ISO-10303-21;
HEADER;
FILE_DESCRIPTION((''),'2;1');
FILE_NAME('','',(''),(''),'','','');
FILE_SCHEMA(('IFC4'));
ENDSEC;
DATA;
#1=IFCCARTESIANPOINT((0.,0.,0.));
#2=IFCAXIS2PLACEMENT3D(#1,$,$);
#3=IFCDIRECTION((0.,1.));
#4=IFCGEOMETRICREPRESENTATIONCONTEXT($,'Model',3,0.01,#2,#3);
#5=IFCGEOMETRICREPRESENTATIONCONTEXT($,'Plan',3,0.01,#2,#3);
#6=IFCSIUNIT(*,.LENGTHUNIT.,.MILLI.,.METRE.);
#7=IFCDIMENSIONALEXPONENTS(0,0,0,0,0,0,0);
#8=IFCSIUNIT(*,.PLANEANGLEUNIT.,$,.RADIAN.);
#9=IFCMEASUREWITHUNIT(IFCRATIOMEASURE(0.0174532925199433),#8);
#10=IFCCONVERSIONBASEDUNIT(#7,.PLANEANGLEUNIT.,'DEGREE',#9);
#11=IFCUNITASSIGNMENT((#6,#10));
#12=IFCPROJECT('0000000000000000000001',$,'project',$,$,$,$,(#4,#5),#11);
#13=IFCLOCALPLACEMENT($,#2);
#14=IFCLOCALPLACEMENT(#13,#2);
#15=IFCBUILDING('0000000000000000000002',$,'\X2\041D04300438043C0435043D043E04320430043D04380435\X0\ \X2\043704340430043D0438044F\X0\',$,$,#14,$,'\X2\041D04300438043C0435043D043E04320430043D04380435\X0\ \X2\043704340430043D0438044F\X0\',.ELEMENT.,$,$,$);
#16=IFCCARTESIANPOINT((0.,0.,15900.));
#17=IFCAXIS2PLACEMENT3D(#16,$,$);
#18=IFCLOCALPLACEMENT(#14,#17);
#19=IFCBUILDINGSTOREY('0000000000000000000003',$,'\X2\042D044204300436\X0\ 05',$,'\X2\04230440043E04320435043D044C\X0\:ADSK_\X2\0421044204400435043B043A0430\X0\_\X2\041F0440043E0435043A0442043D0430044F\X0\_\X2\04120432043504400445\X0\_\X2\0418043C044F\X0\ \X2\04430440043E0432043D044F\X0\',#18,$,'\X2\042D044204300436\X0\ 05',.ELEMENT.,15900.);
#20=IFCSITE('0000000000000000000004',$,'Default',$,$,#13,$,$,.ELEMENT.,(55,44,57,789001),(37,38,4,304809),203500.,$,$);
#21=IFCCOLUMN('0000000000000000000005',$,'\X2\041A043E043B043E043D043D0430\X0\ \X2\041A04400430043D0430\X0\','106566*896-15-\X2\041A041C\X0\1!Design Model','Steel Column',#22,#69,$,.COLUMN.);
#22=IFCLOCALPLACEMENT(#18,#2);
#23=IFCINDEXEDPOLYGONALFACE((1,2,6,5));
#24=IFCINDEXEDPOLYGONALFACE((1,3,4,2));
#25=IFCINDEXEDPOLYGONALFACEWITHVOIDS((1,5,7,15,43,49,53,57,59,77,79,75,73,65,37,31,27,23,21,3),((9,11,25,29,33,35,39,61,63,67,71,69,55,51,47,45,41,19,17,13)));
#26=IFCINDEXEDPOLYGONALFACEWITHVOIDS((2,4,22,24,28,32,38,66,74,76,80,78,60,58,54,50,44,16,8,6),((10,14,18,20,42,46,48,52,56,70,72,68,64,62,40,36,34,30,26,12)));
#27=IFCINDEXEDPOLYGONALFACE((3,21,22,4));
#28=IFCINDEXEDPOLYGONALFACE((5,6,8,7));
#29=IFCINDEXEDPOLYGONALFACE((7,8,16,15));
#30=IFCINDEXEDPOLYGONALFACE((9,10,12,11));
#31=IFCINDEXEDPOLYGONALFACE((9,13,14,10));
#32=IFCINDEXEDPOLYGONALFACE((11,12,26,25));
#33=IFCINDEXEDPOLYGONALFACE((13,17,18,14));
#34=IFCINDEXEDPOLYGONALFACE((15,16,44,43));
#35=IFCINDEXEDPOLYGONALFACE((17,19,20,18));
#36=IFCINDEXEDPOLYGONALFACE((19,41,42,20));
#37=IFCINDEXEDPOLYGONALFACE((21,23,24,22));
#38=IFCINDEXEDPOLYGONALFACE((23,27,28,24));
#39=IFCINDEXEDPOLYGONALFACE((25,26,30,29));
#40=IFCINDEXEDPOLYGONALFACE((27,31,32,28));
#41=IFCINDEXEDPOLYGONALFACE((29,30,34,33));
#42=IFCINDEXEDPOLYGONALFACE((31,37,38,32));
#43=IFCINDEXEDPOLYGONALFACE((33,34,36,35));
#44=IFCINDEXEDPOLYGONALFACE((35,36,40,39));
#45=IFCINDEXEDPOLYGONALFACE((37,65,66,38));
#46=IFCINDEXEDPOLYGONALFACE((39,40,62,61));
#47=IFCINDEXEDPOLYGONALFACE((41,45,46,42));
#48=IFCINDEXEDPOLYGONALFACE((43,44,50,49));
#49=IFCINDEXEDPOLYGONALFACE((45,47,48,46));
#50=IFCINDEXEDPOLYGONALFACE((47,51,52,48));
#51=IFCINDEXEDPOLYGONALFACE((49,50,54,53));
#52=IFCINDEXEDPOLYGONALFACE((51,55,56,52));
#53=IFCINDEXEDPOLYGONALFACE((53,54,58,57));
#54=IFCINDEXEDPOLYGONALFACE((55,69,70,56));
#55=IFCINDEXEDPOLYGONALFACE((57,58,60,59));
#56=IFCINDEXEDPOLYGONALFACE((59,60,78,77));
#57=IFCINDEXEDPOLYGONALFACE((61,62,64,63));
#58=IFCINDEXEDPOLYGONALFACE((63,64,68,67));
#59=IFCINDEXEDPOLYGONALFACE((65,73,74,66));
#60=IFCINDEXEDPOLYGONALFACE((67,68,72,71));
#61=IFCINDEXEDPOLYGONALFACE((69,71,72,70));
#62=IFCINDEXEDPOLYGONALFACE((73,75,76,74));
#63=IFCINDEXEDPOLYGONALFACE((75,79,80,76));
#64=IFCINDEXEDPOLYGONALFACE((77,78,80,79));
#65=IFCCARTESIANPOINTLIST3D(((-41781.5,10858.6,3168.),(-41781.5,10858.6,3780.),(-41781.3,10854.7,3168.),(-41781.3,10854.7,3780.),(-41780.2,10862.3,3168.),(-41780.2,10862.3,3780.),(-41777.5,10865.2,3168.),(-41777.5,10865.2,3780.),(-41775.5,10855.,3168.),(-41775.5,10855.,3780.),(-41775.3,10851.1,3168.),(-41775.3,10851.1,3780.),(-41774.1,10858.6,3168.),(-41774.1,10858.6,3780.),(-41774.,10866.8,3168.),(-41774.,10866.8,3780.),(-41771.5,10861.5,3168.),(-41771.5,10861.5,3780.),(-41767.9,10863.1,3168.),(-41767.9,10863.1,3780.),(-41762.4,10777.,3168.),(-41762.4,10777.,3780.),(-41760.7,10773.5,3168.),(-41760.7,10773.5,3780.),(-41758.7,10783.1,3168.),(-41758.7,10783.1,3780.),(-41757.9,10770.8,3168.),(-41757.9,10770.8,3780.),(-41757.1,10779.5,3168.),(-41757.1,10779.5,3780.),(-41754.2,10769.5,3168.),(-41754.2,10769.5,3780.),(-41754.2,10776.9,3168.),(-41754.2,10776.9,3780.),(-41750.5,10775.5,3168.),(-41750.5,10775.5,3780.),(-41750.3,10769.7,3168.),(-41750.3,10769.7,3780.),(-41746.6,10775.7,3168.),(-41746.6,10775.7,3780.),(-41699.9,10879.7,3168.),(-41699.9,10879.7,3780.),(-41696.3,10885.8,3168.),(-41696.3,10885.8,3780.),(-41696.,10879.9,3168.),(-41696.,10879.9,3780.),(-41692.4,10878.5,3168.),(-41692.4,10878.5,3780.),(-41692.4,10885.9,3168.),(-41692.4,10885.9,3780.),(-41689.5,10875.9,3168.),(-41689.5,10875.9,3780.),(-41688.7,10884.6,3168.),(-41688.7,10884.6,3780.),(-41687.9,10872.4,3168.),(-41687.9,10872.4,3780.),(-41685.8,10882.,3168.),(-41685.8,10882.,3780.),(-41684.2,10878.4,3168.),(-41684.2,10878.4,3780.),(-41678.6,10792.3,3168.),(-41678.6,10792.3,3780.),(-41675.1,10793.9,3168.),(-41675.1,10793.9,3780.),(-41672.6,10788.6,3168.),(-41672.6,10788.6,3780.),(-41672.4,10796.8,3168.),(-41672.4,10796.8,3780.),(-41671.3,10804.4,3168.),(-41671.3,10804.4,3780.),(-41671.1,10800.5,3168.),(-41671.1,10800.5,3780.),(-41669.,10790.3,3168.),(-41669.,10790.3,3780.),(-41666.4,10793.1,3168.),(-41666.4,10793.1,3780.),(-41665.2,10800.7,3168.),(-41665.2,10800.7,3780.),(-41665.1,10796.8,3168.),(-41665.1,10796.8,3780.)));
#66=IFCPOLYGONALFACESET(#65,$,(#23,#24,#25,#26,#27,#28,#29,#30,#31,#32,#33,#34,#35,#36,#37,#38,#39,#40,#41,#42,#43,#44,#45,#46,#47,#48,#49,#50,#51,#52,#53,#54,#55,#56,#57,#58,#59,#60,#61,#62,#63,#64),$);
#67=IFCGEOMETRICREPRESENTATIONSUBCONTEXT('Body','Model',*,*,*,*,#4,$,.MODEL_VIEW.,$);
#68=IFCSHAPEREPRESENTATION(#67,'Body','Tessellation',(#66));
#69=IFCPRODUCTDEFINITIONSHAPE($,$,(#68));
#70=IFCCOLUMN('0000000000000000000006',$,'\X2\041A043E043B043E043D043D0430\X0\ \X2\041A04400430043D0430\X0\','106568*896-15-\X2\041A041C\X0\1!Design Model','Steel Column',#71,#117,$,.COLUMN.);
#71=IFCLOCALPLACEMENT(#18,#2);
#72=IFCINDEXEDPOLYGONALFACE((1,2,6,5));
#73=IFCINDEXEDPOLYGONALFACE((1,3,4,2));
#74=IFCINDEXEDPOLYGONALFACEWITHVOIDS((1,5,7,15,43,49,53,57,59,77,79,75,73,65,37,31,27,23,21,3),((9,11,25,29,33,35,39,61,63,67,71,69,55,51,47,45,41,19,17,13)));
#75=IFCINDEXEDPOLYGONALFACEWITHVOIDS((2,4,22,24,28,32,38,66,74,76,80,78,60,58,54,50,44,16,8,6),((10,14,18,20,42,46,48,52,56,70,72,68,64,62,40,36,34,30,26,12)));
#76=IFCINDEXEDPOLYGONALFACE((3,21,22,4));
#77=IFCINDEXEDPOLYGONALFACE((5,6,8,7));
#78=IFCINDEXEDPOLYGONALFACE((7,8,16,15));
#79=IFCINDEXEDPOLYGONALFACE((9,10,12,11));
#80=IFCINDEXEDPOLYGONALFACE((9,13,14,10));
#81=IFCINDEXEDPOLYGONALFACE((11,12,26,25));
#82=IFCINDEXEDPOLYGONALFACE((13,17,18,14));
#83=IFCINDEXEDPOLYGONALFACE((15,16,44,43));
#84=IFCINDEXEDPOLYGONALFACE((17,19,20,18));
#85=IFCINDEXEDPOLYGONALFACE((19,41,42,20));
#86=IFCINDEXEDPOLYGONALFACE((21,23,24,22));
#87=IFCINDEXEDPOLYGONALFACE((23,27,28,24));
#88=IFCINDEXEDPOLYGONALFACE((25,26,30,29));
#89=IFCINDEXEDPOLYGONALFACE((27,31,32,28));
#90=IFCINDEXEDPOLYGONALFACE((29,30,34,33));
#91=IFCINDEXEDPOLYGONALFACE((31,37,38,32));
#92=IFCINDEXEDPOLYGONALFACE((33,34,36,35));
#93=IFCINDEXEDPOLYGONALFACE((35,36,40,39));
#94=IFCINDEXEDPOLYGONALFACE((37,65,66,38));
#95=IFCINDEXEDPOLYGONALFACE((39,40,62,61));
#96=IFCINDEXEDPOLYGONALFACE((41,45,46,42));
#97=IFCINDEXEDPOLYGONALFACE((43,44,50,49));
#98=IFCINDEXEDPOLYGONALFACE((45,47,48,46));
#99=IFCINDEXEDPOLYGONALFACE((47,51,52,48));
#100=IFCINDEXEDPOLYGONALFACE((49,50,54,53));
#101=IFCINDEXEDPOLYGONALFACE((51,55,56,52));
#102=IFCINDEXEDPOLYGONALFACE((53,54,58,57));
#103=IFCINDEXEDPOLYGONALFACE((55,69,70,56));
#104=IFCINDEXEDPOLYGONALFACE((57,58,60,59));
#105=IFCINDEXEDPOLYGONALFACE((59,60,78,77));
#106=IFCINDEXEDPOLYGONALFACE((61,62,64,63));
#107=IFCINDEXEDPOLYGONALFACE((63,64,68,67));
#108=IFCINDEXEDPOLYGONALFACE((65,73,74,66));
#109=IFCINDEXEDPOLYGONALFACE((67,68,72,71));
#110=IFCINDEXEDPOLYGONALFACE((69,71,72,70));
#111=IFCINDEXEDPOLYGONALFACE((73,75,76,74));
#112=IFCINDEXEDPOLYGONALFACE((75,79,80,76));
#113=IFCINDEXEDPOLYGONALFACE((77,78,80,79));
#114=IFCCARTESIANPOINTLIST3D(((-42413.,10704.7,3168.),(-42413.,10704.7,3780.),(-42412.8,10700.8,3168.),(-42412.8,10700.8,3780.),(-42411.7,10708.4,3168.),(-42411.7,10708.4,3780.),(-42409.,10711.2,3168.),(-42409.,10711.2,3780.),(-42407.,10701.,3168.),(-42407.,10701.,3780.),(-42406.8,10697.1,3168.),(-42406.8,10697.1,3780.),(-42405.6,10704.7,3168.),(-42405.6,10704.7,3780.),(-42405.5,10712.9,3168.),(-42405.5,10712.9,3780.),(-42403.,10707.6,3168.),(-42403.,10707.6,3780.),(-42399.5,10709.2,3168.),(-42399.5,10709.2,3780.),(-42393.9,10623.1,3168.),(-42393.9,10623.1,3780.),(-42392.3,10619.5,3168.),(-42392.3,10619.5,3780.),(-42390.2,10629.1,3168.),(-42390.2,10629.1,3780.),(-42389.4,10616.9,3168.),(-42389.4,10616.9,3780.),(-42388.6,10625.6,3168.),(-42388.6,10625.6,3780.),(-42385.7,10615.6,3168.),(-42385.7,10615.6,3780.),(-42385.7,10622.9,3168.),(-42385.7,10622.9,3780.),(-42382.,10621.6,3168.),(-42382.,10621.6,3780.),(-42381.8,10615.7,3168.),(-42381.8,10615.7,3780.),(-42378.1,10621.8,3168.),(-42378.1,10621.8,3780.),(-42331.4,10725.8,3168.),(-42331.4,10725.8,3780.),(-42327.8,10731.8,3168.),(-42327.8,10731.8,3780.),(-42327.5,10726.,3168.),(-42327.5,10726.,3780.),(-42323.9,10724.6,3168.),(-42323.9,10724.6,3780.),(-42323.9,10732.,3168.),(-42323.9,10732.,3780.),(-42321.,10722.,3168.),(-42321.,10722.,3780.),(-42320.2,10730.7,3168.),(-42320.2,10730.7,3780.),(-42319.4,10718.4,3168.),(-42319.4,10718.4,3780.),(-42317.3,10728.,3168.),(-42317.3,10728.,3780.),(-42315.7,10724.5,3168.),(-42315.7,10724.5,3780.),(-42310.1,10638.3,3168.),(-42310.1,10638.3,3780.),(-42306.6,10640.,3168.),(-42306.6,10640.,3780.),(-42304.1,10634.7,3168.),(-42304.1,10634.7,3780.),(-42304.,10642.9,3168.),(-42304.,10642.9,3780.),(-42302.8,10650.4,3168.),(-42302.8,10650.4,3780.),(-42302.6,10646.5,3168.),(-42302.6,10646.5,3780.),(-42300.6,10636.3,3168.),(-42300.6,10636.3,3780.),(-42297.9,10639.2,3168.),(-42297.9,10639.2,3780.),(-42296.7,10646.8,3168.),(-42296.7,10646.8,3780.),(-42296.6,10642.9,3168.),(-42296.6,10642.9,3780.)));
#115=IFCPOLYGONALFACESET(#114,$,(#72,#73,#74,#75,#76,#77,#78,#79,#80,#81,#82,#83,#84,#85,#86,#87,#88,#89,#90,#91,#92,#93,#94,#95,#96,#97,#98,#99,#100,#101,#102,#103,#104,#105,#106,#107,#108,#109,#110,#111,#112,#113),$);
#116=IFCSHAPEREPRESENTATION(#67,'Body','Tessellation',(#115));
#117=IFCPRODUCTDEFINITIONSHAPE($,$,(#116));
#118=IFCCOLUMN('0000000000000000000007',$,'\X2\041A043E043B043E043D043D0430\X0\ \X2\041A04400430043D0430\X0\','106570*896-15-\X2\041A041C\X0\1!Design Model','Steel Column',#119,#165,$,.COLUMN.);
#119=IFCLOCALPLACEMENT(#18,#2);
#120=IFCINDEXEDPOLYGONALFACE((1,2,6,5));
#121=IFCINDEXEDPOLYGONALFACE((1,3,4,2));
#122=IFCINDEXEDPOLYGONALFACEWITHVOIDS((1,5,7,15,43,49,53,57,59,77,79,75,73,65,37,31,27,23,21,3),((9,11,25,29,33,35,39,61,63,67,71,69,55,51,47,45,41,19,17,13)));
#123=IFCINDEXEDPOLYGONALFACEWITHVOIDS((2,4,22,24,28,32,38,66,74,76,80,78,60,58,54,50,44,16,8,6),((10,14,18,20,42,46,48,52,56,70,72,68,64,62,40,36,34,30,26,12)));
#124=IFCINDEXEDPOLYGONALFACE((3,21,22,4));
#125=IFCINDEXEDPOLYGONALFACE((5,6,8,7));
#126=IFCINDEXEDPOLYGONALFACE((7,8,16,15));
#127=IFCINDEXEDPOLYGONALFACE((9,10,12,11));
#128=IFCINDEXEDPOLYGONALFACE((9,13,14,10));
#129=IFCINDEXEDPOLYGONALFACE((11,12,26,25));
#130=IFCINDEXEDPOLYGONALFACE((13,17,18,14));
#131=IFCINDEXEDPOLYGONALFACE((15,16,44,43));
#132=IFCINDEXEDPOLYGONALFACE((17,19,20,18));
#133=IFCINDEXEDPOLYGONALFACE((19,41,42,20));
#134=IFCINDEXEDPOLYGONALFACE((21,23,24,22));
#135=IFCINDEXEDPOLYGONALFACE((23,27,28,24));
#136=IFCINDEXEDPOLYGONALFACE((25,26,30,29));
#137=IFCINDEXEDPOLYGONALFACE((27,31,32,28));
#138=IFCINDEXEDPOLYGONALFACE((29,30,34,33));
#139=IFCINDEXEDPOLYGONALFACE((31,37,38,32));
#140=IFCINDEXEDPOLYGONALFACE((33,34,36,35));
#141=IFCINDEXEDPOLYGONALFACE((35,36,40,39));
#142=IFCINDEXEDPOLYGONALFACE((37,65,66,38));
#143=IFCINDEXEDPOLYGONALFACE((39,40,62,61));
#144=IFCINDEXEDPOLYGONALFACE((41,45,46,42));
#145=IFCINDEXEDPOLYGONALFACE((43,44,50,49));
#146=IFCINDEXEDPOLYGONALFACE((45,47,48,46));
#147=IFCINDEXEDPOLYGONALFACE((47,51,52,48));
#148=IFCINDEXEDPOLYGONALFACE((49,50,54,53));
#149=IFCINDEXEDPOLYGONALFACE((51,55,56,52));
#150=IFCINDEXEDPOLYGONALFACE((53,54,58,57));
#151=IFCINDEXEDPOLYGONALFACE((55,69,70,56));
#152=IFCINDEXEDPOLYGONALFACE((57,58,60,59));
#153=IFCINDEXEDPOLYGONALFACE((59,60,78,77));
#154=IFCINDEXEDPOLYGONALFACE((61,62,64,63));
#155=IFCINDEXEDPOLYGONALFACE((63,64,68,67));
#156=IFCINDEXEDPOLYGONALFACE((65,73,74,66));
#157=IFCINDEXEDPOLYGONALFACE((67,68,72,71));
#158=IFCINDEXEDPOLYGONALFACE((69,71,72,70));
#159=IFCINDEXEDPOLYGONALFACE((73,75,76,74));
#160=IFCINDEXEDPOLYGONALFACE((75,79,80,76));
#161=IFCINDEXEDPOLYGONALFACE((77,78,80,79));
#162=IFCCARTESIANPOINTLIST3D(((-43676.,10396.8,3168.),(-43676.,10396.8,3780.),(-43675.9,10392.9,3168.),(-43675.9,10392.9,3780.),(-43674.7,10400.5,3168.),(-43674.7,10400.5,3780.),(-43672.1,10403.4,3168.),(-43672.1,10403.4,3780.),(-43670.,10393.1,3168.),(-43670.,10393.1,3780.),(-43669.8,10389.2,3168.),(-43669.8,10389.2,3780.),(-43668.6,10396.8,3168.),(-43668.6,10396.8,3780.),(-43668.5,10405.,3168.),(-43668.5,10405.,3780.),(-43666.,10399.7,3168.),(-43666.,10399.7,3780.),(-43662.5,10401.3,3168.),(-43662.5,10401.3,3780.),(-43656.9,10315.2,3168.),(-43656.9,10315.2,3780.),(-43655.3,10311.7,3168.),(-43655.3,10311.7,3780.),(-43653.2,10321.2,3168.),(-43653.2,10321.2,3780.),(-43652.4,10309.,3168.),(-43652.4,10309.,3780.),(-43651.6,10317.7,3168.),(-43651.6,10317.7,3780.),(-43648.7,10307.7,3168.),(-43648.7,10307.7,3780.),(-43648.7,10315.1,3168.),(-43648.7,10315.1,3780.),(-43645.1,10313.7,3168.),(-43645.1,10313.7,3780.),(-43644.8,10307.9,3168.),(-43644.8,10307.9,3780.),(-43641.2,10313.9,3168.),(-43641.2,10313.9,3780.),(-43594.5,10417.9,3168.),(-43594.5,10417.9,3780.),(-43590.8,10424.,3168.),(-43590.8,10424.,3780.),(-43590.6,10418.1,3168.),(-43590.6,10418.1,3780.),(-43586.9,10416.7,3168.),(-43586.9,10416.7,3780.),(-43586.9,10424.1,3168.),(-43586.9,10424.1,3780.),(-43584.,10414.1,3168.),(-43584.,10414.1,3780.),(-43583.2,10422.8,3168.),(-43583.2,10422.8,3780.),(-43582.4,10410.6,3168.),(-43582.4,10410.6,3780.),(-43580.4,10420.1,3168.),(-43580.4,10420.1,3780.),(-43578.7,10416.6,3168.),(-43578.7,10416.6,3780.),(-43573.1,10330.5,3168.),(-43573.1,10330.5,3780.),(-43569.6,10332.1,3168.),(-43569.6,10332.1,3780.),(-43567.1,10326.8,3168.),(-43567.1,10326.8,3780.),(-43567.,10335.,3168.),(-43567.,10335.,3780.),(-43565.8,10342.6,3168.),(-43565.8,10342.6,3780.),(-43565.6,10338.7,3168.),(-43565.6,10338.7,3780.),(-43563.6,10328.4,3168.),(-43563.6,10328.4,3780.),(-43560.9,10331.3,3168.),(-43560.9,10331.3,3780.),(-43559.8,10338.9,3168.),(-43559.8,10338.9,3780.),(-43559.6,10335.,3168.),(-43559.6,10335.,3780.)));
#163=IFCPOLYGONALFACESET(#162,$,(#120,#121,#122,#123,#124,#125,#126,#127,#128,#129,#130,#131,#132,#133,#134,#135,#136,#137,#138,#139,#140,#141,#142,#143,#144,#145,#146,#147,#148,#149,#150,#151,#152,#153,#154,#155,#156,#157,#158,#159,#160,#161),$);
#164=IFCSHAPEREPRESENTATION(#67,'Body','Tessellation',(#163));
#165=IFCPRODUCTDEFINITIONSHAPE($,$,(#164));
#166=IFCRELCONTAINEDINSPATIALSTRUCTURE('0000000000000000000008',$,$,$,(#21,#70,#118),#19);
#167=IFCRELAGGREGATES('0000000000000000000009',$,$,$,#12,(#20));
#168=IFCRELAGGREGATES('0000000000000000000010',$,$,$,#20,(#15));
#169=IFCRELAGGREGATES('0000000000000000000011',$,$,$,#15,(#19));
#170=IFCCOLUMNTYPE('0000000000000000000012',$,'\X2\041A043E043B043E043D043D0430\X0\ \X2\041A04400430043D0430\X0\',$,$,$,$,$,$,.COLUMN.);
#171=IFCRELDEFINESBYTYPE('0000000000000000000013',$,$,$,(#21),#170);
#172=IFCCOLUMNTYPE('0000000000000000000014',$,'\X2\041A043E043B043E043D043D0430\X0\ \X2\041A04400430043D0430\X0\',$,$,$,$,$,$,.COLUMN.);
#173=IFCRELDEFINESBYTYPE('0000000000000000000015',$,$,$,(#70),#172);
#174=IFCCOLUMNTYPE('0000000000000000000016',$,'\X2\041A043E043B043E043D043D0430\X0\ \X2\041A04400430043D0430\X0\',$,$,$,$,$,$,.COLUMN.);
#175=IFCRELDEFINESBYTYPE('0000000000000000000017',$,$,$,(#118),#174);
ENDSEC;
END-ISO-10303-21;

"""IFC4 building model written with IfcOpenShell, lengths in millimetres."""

from ifc_helpers import new_model, entity, si_unit, converted_unit, direction, frame, origin, place, context, subcontext, project, spatial, indexed_curve, outline, extrude, type_object, element, save


model = new_model("IFC4")

# Units and contexts
model_context = context("Model", 3, precision=0.01, world=origin(), true_north=direction((0.0, 1.0)))
plan_context = context("Plan", 3, precision=0.01, world=origin(), true_north=direction((0.0, 1.0)))
body_context = subcontext(model_context, "Body", "Model", "MODEL_VIEW")
ifc_project = project(units=[si_unit("LENGTHUNIT", "METRE", prefix="MILLI"), converted_unit("PLANEANGLEUNIT", "DEGREE", entity("IfcRatioMeasure", 0.0174532925199433), si_unit("PLANEANGLEUNIT", "RADIAN"), dimensions=[0, 0, 0, 0, 0, 0, 0])], contexts=[model_context, plan_context])

# Site, building, storey
site_placement = place(None, origin())
site = spatial("IfcSite", under=ifc_project, at=site_placement, Name="Default", CompositionType="ELEMENT", RefLatitude=(55, 44, 57, 789001), RefLongitude=(37, 38, 4, 304809), RefElevation=203500.0)
building_placement = place(site_placement, origin())
building = spatial("IfcBuilding", under=site, at=building_placement, Name="Наименование здания", LongName="Наименование здания", CompositionType="ELEMENT")
storey_placement = place(building_placement, frame((0.0, 0.0, 15900.0)))
storey = spatial("IfcBuildingStorey", under=building, at=storey_placement, Name="Этаж 05", ObjectType="Уровень:ADSK_Стрелка_Проектная_Вверх_Имя уровня", LongName="Этаж 05", CompositionType="ELEMENT", Elevation=15900.0)

# Columns
column_type_1 = type_object("IfcColumnType", Name="Колонна Крана", PredefinedType="COLUMN")
column_1_placement = place(storey_placement, origin())
element("IfcColumn", 1, at=column_1_placement, inside=storey, type_object=column_type_1, Name="Колонна Крана", Description="106566*896-15-КМ1!Design Model", ObjectType="Steel Column", PredefinedType="COLUMN", context=body_context, shape_type="SweptSolid", body=[
    extrude(outline(indexed_curve([(29.5, -56.8), (33.4, -56.8), (37.0, -55.3), (39.7, -52.6), (41.2, -49.0), (56.8, 29.5), (56.8, 33.4), (55.3, 37.0), (52.6, 39.7), (49.0, 41.2), (-29.5, 56.8), (-33.4, 56.8), (-37.0, 55.3), (-39.7, 52.6), (-41.2, 49.0), (-56.8, -29.5), (-56.8, -33.4), (-55.3, -37.0), (-52.6, -39.7), (-49.0, -41.2), (29.5, -56.8)], self_intersect=False), holes=[indexed_curve([(-43.1, -37.3), (-46.7, -35.8), (-49.5, -33.1), (-51.0, -29.5), (-51.0, -25.5), (-37.3, 43.1), (-35.8, 46.7), (-33.1, 49.5), (-29.5, 51.0), (-25.5, 51.0), (43.1, 37.3), (46.7, 35.8), (49.5, 33.1), (51.0, 29.5), (51.0, 25.5), (37.3, -43.1), (35.8, -46.7), (33.1, -49.5), (29.5, -51.0), (25.5, -51.0), (-43.1, -37.3)], self_intersect=False)]), frame((-41723.3, 10827.7, 3168.0), z_axis=(0.0, 0.0, 1.0), x_axis=(0.906681, 0.421816, 0.0)), (0.0, 0.0, 1.0), 612.0),
])
column_type_2 = type_object("IfcColumnType", Name="Колонна Крана", PredefinedType="COLUMN")
column_2_placement = place(storey_placement, origin())
element("IfcColumn", 2, at=column_2_placement, inside=storey, type_object=column_type_2, Name="Колонна Крана", Description="106568*896-15-КМ1!Design Model", ObjectType="Steel Column", PredefinedType="COLUMN", context=body_context, shape_type="SweptSolid", body=[
    extrude(outline(indexed_curve([(29.5, -56.8), (33.4, -56.8), (37.0, -55.3), (39.7, -52.6), (41.2, -49.0), (56.8, 29.5), (56.8, 33.4), (55.3, 37.0), (52.6, 39.7), (49.0, 41.2), (-29.5, 56.8), (-33.4, 56.8), (-37.0, 55.3), (-39.7, 52.6), (-41.2, 49.0), (-56.8, -29.5), (-56.8, -33.4), (-55.3, -37.0), (-52.6, -39.7), (-49.0, -41.2), (29.5, -56.8)], self_intersect=False), holes=[indexed_curve([(-43.1, -37.3), (-46.7, -35.8), (-49.5, -33.1), (-51.0, -29.5), (-51.0, -25.5), (-37.3, 43.1), (-35.8, 46.7), (-33.1, 49.5), (-29.5, 51.0), (-25.5, 51.0), (43.1, 37.3), (46.7, 35.8), (49.5, 33.1), (51.0, 29.5), (51.0, 25.5), (37.3, -43.1), (35.8, -46.7), (33.1, -49.5), (29.5, -51.0), (25.5, -51.0), (-43.1, -37.3)], self_intersect=False)]), frame((-42354.8, 10673.8, 3168.0), z_axis=(0.0, 0.0, 1.0), x_axis=(0.906681, 0.421816, 0.0)), (0.0, 0.0, 1.0), 612.0),
])
column_type_3 = type_object("IfcColumnType", Name="Колонна Крана", PredefinedType="COLUMN")
column_3_placement = place(storey_placement, origin())
element("IfcColumn", 3, at=column_3_placement, inside=storey, type_object=column_type_3, Name="Колонна Крана", Description="106570*896-15-КМ1!Design Model", ObjectType="Steel Column", PredefinedType="COLUMN", context=body_context, shape_type="SweptSolid", body=[
    extrude(outline(indexed_curve([(29.5, -56.8), (33.4, -56.8), (37.0, -55.3), (39.7, -52.6), (41.2, -49.0), (56.8, 29.5), (56.8, 33.4), (55.3, 37.0), (52.6, 39.7), (49.0, 41.2), (-29.5, 56.8), (-33.4, 56.8), (-37.0, 55.3), (-39.7, 52.6), (-41.2, 49.0), (-56.8, -29.5), (-56.8, -33.4), (-55.3, -37.0), (-52.6, -39.7), (-49.0, -41.2), (29.5, -56.8)], self_intersect=False), holes=[indexed_curve([(-43.1, -37.3), (-46.7, -35.8), (-49.5, -33.1), (-51.0, -29.5), (-51.0, -25.5), (-37.3, 43.1), (-35.8, 46.7), (-33.1, 49.5), (-29.5, 51.0), (-25.5, 51.0), (43.1, 37.3), (46.7, 35.8), (49.5, 33.1), (51.0, 29.5), (51.0, 25.5), (37.3, -43.1), (35.8, -46.7), (33.1, -49.5), (29.5, -51.0), (25.5, -51.0), (-43.1, -37.3)], self_intersect=False)]), frame((-43617.8, 10365.9, 3168.0), z_axis=(0.0, 0.0, 1.0), x_axis=(0.906681, 0.421816, 0.0)), (0.0, 0.0, 1.0), 612.0),
])

save(model, "model.ifc")
